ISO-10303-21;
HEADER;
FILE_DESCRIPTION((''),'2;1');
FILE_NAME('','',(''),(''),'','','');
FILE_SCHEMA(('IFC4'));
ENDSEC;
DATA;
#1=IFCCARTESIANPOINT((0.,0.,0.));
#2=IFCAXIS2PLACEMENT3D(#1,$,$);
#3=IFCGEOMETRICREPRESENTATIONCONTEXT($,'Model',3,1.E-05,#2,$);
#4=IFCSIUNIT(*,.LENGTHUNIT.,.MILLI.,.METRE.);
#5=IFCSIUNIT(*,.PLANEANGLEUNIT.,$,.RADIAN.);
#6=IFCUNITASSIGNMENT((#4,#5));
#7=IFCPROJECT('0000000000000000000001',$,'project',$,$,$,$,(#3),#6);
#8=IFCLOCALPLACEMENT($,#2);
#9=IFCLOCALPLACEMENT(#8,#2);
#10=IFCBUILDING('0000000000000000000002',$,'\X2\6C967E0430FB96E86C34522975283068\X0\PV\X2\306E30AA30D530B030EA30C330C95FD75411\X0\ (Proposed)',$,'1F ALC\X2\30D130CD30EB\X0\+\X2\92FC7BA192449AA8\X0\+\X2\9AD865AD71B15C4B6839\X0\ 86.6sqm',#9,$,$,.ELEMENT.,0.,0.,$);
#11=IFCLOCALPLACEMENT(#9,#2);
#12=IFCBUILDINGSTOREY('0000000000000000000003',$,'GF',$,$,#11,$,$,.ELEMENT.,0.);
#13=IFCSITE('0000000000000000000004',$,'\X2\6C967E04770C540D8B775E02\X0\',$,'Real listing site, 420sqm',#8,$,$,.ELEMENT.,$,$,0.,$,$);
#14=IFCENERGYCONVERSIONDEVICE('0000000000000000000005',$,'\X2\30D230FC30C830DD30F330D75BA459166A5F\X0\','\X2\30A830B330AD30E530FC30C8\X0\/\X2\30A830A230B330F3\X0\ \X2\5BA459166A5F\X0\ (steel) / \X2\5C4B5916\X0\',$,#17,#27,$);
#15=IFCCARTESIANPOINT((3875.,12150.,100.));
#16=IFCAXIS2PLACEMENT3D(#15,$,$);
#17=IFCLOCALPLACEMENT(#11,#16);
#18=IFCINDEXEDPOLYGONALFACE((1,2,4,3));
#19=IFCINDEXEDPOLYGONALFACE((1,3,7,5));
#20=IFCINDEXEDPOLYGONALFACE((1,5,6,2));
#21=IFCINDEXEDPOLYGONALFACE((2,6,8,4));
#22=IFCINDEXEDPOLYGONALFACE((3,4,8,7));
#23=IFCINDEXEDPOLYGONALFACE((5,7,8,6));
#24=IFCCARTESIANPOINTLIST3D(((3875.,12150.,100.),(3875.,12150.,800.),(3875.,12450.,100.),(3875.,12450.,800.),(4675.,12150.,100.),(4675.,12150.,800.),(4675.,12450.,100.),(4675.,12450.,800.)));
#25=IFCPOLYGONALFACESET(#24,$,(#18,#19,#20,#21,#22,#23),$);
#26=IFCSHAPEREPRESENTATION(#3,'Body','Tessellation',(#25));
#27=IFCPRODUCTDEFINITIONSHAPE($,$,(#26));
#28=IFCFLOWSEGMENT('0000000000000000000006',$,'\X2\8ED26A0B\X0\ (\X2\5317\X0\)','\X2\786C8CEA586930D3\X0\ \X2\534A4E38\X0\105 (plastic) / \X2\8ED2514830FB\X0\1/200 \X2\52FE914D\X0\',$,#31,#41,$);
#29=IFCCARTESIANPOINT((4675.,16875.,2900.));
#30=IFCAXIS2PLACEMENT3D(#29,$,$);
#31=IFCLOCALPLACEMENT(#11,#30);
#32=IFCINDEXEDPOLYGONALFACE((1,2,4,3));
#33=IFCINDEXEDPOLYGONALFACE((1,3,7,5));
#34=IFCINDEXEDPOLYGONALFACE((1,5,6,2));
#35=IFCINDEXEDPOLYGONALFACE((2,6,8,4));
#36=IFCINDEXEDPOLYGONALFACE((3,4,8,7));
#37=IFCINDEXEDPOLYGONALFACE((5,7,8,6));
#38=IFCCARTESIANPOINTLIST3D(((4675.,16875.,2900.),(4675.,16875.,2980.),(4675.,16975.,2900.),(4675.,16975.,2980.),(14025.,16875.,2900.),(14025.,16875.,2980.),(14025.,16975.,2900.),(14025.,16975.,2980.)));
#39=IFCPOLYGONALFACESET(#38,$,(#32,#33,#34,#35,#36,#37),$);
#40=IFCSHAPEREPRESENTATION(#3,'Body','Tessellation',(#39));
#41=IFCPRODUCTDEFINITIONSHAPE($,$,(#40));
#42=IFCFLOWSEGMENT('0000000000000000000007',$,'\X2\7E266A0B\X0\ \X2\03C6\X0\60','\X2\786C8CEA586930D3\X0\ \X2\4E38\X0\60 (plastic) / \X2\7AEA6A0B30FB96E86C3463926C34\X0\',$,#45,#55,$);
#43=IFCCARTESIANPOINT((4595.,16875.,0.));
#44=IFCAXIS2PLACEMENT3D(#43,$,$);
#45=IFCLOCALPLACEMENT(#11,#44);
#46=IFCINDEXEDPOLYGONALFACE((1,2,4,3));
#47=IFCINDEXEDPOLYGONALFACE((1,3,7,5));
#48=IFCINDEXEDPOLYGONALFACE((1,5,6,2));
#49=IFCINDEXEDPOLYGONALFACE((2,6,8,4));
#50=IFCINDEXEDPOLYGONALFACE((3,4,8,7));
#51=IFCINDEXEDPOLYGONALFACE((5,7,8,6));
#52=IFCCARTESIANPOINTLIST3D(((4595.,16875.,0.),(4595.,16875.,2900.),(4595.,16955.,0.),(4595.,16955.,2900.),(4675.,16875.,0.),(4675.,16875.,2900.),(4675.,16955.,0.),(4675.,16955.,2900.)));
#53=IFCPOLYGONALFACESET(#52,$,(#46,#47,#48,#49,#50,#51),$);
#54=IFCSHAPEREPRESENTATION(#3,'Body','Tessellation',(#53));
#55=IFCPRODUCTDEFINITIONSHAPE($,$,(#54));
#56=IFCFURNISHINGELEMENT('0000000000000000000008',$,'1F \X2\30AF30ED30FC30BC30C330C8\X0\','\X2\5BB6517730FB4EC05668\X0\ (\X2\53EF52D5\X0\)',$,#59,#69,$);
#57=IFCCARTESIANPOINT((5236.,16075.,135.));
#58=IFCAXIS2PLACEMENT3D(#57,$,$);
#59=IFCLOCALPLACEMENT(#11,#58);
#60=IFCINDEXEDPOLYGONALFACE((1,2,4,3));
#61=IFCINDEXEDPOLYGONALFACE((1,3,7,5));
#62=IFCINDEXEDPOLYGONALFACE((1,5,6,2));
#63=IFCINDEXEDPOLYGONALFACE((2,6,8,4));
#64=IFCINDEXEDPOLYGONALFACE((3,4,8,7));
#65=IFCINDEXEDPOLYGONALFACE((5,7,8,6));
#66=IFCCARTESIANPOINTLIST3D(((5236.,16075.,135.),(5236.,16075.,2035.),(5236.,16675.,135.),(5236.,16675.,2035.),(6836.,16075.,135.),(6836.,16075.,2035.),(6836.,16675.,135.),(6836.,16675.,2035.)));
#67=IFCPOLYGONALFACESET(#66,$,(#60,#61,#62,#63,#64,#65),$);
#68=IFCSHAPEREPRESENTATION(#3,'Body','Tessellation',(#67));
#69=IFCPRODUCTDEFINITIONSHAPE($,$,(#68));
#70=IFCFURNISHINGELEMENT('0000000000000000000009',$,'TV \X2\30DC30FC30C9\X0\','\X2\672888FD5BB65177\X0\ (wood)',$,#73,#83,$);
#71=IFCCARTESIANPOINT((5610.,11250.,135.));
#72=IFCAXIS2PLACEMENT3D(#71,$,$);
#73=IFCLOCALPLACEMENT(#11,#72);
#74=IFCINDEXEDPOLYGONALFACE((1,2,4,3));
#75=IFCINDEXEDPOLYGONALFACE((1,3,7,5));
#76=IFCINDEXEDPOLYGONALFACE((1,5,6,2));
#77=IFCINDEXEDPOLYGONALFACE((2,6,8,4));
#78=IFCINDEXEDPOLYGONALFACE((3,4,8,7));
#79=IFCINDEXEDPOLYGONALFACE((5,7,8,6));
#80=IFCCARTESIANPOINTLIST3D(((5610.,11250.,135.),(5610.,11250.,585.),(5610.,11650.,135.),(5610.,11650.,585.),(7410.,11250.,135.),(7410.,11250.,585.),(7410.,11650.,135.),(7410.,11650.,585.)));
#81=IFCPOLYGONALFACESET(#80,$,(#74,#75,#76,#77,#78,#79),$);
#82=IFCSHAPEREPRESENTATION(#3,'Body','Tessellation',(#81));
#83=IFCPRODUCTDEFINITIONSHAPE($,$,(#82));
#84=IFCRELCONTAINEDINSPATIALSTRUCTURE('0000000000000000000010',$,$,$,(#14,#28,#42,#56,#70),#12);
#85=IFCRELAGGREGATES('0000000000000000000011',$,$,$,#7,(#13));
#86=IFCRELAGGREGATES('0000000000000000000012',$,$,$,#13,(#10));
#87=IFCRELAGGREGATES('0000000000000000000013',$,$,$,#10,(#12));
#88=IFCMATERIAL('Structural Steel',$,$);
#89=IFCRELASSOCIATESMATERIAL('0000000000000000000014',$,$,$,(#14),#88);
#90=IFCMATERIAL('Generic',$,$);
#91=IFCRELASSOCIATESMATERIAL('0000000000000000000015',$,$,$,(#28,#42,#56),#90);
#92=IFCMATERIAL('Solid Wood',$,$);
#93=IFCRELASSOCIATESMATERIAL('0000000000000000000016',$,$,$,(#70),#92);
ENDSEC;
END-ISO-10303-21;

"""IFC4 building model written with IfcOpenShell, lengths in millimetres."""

from ifc_helpers import new_model, si_unit, frame, frame_2d, origin, place, context, project, spatial, rectangle, extrude, material, element, save


model = new_model("IFC4")

# Units and contexts
model_context = context("Model", 3, precision=1e-05, world=origin())
ifc_project = project(units=[si_unit("LENGTHUNIT", "METRE", prefix="MILLI"), si_unit("PLANEANGLEUNIT", "RADIAN")], contexts=[model_context])

# Site, building, storey
site_placement = place(None, origin())
site = spatial("IfcSite", under=ifc_project, at=site_placement, Name="沖縄県名護市", ObjectType="Real listing site, 420sqm", CompositionType="ELEMENT", RefElevation=0.0)
building_placement = place(site_placement, origin())
building = spatial("IfcBuilding", under=site, at=building_placement, Name="沖縄・雨水利用とPVのオフグリッド志向 (Proposed)", ObjectType="1F ALCパネル+鋼管鉄骨+高断熱屋根 86.6sqm", CompositionType="ELEMENT", ElevationOfRefHeight=0.0, ElevationOfTerrain=0.0)
storey_placement = place(building_placement, origin())
storey = spatial("IfcBuildingStorey", under=building, at=storey_placement, Name="GF", CompositionType="ELEMENT", Elevation=0.0)

# Shared definitions
ifc_material_1 = material(Name="Solid Wood")

# Shared definitions
ifc_material_2 = material(Name="Structural Steel")

# Shared definitions
ifc_material_3 = material(Name="Generic")

# Energy conversion device
energy_conversion_device_placement = place(storey_placement, frame((3875.0, 12150.0, 100.0)))
element("IfcEnergyConversionDevice", 1, at=energy_conversion_device_placement, inside=storey, material=ifc_material_2, Name="ヒートポンプ室外機", Description="エコキュート/エアコン 室外機 (steel) / 屋外", context=model_context, shape_type="SweptSolid", body=[
    extrude(rectangle(XDim=800.0, YDim=300.0, at=frame_2d((400.0, 150.0))), frame((3875.0, 12150.0, 100.0)), (0.0, 0.0, 1.0), 700.0),
])

# Flow segments
flow_segment_1_placement = place(storey_placement, frame((4675.0, 16875.0, 2900.0)))
element("IfcFlowSegment", 2, at=flow_segment_1_placement, inside=storey, material=ifc_material_3, Name="軒樋 (北)", Description="硬質塩ビ 半丸105 (plastic) / 軒先・1/200 勾配", context=model_context, shape_type="SweptSolid", body=[
    extrude(rectangle(XDim=9350.0, YDim=100.0, at=frame_2d((4675.0, 50.0))), frame((4675.0, 16875.0, 2900.0)), (0.0, 0.0, 1.0), 80.0),
])
flow_segment_2_placement = place(storey_placement, frame((4595.0, 16875.0, 0.0)))
element("IfcFlowSegment", 3, at=flow_segment_2_placement, inside=storey, material=ifc_material_3, Name="縦樋 φ60", Description="硬質塩ビ 丸60 (plastic) / 竪樋・雨水排水", context=model_context, shape_type="SweptSolid", body=[
    extrude(rectangle(XDim=80.0, YDim=80.0, at=frame_2d((40.0, 40.0))), frame((4595.0, 16875.0, 0.0)), (0.0, 0.0, 1.0), 2900.0),
])

# Furnishing elements
furnishing_1_placement = place(storey_placement, frame((5236.0, 16075.0, 135.0)))
element("IfcFurnishingElement", 4, at=furnishing_1_placement, inside=storey, material=ifc_material_3, Name="1F クローゼット", Description="家具・什器 (可動)", context=model_context, shape_type="SweptSolid", body=[
    extrude(rectangle(XDim=1600.0, YDim=600.0, at=frame_2d((800.0, 300.0))), frame((5236.0, 16075.0, 135.0)), (0.0, 0.0, 1.0), 1900.0),
])
furnishing_2_placement = place(storey_placement, frame((5610.0, 11250.0, 135.0)))
element("IfcFurnishingElement", 5, at=furnishing_2_placement, inside=storey, material=ifc_material_1, Name="TV ボード", Description="木製家具 (wood)", context=model_context, shape_type="SweptSolid", body=[
    extrude(rectangle(XDim=1800.0, YDim=400.0, at=frame_2d((900.0, 200.0))), frame((5610.0, 11250.0, 135.0)), (0.0, 0.0, 1.0), 450.0),
])

save(model, "model.ifc")
